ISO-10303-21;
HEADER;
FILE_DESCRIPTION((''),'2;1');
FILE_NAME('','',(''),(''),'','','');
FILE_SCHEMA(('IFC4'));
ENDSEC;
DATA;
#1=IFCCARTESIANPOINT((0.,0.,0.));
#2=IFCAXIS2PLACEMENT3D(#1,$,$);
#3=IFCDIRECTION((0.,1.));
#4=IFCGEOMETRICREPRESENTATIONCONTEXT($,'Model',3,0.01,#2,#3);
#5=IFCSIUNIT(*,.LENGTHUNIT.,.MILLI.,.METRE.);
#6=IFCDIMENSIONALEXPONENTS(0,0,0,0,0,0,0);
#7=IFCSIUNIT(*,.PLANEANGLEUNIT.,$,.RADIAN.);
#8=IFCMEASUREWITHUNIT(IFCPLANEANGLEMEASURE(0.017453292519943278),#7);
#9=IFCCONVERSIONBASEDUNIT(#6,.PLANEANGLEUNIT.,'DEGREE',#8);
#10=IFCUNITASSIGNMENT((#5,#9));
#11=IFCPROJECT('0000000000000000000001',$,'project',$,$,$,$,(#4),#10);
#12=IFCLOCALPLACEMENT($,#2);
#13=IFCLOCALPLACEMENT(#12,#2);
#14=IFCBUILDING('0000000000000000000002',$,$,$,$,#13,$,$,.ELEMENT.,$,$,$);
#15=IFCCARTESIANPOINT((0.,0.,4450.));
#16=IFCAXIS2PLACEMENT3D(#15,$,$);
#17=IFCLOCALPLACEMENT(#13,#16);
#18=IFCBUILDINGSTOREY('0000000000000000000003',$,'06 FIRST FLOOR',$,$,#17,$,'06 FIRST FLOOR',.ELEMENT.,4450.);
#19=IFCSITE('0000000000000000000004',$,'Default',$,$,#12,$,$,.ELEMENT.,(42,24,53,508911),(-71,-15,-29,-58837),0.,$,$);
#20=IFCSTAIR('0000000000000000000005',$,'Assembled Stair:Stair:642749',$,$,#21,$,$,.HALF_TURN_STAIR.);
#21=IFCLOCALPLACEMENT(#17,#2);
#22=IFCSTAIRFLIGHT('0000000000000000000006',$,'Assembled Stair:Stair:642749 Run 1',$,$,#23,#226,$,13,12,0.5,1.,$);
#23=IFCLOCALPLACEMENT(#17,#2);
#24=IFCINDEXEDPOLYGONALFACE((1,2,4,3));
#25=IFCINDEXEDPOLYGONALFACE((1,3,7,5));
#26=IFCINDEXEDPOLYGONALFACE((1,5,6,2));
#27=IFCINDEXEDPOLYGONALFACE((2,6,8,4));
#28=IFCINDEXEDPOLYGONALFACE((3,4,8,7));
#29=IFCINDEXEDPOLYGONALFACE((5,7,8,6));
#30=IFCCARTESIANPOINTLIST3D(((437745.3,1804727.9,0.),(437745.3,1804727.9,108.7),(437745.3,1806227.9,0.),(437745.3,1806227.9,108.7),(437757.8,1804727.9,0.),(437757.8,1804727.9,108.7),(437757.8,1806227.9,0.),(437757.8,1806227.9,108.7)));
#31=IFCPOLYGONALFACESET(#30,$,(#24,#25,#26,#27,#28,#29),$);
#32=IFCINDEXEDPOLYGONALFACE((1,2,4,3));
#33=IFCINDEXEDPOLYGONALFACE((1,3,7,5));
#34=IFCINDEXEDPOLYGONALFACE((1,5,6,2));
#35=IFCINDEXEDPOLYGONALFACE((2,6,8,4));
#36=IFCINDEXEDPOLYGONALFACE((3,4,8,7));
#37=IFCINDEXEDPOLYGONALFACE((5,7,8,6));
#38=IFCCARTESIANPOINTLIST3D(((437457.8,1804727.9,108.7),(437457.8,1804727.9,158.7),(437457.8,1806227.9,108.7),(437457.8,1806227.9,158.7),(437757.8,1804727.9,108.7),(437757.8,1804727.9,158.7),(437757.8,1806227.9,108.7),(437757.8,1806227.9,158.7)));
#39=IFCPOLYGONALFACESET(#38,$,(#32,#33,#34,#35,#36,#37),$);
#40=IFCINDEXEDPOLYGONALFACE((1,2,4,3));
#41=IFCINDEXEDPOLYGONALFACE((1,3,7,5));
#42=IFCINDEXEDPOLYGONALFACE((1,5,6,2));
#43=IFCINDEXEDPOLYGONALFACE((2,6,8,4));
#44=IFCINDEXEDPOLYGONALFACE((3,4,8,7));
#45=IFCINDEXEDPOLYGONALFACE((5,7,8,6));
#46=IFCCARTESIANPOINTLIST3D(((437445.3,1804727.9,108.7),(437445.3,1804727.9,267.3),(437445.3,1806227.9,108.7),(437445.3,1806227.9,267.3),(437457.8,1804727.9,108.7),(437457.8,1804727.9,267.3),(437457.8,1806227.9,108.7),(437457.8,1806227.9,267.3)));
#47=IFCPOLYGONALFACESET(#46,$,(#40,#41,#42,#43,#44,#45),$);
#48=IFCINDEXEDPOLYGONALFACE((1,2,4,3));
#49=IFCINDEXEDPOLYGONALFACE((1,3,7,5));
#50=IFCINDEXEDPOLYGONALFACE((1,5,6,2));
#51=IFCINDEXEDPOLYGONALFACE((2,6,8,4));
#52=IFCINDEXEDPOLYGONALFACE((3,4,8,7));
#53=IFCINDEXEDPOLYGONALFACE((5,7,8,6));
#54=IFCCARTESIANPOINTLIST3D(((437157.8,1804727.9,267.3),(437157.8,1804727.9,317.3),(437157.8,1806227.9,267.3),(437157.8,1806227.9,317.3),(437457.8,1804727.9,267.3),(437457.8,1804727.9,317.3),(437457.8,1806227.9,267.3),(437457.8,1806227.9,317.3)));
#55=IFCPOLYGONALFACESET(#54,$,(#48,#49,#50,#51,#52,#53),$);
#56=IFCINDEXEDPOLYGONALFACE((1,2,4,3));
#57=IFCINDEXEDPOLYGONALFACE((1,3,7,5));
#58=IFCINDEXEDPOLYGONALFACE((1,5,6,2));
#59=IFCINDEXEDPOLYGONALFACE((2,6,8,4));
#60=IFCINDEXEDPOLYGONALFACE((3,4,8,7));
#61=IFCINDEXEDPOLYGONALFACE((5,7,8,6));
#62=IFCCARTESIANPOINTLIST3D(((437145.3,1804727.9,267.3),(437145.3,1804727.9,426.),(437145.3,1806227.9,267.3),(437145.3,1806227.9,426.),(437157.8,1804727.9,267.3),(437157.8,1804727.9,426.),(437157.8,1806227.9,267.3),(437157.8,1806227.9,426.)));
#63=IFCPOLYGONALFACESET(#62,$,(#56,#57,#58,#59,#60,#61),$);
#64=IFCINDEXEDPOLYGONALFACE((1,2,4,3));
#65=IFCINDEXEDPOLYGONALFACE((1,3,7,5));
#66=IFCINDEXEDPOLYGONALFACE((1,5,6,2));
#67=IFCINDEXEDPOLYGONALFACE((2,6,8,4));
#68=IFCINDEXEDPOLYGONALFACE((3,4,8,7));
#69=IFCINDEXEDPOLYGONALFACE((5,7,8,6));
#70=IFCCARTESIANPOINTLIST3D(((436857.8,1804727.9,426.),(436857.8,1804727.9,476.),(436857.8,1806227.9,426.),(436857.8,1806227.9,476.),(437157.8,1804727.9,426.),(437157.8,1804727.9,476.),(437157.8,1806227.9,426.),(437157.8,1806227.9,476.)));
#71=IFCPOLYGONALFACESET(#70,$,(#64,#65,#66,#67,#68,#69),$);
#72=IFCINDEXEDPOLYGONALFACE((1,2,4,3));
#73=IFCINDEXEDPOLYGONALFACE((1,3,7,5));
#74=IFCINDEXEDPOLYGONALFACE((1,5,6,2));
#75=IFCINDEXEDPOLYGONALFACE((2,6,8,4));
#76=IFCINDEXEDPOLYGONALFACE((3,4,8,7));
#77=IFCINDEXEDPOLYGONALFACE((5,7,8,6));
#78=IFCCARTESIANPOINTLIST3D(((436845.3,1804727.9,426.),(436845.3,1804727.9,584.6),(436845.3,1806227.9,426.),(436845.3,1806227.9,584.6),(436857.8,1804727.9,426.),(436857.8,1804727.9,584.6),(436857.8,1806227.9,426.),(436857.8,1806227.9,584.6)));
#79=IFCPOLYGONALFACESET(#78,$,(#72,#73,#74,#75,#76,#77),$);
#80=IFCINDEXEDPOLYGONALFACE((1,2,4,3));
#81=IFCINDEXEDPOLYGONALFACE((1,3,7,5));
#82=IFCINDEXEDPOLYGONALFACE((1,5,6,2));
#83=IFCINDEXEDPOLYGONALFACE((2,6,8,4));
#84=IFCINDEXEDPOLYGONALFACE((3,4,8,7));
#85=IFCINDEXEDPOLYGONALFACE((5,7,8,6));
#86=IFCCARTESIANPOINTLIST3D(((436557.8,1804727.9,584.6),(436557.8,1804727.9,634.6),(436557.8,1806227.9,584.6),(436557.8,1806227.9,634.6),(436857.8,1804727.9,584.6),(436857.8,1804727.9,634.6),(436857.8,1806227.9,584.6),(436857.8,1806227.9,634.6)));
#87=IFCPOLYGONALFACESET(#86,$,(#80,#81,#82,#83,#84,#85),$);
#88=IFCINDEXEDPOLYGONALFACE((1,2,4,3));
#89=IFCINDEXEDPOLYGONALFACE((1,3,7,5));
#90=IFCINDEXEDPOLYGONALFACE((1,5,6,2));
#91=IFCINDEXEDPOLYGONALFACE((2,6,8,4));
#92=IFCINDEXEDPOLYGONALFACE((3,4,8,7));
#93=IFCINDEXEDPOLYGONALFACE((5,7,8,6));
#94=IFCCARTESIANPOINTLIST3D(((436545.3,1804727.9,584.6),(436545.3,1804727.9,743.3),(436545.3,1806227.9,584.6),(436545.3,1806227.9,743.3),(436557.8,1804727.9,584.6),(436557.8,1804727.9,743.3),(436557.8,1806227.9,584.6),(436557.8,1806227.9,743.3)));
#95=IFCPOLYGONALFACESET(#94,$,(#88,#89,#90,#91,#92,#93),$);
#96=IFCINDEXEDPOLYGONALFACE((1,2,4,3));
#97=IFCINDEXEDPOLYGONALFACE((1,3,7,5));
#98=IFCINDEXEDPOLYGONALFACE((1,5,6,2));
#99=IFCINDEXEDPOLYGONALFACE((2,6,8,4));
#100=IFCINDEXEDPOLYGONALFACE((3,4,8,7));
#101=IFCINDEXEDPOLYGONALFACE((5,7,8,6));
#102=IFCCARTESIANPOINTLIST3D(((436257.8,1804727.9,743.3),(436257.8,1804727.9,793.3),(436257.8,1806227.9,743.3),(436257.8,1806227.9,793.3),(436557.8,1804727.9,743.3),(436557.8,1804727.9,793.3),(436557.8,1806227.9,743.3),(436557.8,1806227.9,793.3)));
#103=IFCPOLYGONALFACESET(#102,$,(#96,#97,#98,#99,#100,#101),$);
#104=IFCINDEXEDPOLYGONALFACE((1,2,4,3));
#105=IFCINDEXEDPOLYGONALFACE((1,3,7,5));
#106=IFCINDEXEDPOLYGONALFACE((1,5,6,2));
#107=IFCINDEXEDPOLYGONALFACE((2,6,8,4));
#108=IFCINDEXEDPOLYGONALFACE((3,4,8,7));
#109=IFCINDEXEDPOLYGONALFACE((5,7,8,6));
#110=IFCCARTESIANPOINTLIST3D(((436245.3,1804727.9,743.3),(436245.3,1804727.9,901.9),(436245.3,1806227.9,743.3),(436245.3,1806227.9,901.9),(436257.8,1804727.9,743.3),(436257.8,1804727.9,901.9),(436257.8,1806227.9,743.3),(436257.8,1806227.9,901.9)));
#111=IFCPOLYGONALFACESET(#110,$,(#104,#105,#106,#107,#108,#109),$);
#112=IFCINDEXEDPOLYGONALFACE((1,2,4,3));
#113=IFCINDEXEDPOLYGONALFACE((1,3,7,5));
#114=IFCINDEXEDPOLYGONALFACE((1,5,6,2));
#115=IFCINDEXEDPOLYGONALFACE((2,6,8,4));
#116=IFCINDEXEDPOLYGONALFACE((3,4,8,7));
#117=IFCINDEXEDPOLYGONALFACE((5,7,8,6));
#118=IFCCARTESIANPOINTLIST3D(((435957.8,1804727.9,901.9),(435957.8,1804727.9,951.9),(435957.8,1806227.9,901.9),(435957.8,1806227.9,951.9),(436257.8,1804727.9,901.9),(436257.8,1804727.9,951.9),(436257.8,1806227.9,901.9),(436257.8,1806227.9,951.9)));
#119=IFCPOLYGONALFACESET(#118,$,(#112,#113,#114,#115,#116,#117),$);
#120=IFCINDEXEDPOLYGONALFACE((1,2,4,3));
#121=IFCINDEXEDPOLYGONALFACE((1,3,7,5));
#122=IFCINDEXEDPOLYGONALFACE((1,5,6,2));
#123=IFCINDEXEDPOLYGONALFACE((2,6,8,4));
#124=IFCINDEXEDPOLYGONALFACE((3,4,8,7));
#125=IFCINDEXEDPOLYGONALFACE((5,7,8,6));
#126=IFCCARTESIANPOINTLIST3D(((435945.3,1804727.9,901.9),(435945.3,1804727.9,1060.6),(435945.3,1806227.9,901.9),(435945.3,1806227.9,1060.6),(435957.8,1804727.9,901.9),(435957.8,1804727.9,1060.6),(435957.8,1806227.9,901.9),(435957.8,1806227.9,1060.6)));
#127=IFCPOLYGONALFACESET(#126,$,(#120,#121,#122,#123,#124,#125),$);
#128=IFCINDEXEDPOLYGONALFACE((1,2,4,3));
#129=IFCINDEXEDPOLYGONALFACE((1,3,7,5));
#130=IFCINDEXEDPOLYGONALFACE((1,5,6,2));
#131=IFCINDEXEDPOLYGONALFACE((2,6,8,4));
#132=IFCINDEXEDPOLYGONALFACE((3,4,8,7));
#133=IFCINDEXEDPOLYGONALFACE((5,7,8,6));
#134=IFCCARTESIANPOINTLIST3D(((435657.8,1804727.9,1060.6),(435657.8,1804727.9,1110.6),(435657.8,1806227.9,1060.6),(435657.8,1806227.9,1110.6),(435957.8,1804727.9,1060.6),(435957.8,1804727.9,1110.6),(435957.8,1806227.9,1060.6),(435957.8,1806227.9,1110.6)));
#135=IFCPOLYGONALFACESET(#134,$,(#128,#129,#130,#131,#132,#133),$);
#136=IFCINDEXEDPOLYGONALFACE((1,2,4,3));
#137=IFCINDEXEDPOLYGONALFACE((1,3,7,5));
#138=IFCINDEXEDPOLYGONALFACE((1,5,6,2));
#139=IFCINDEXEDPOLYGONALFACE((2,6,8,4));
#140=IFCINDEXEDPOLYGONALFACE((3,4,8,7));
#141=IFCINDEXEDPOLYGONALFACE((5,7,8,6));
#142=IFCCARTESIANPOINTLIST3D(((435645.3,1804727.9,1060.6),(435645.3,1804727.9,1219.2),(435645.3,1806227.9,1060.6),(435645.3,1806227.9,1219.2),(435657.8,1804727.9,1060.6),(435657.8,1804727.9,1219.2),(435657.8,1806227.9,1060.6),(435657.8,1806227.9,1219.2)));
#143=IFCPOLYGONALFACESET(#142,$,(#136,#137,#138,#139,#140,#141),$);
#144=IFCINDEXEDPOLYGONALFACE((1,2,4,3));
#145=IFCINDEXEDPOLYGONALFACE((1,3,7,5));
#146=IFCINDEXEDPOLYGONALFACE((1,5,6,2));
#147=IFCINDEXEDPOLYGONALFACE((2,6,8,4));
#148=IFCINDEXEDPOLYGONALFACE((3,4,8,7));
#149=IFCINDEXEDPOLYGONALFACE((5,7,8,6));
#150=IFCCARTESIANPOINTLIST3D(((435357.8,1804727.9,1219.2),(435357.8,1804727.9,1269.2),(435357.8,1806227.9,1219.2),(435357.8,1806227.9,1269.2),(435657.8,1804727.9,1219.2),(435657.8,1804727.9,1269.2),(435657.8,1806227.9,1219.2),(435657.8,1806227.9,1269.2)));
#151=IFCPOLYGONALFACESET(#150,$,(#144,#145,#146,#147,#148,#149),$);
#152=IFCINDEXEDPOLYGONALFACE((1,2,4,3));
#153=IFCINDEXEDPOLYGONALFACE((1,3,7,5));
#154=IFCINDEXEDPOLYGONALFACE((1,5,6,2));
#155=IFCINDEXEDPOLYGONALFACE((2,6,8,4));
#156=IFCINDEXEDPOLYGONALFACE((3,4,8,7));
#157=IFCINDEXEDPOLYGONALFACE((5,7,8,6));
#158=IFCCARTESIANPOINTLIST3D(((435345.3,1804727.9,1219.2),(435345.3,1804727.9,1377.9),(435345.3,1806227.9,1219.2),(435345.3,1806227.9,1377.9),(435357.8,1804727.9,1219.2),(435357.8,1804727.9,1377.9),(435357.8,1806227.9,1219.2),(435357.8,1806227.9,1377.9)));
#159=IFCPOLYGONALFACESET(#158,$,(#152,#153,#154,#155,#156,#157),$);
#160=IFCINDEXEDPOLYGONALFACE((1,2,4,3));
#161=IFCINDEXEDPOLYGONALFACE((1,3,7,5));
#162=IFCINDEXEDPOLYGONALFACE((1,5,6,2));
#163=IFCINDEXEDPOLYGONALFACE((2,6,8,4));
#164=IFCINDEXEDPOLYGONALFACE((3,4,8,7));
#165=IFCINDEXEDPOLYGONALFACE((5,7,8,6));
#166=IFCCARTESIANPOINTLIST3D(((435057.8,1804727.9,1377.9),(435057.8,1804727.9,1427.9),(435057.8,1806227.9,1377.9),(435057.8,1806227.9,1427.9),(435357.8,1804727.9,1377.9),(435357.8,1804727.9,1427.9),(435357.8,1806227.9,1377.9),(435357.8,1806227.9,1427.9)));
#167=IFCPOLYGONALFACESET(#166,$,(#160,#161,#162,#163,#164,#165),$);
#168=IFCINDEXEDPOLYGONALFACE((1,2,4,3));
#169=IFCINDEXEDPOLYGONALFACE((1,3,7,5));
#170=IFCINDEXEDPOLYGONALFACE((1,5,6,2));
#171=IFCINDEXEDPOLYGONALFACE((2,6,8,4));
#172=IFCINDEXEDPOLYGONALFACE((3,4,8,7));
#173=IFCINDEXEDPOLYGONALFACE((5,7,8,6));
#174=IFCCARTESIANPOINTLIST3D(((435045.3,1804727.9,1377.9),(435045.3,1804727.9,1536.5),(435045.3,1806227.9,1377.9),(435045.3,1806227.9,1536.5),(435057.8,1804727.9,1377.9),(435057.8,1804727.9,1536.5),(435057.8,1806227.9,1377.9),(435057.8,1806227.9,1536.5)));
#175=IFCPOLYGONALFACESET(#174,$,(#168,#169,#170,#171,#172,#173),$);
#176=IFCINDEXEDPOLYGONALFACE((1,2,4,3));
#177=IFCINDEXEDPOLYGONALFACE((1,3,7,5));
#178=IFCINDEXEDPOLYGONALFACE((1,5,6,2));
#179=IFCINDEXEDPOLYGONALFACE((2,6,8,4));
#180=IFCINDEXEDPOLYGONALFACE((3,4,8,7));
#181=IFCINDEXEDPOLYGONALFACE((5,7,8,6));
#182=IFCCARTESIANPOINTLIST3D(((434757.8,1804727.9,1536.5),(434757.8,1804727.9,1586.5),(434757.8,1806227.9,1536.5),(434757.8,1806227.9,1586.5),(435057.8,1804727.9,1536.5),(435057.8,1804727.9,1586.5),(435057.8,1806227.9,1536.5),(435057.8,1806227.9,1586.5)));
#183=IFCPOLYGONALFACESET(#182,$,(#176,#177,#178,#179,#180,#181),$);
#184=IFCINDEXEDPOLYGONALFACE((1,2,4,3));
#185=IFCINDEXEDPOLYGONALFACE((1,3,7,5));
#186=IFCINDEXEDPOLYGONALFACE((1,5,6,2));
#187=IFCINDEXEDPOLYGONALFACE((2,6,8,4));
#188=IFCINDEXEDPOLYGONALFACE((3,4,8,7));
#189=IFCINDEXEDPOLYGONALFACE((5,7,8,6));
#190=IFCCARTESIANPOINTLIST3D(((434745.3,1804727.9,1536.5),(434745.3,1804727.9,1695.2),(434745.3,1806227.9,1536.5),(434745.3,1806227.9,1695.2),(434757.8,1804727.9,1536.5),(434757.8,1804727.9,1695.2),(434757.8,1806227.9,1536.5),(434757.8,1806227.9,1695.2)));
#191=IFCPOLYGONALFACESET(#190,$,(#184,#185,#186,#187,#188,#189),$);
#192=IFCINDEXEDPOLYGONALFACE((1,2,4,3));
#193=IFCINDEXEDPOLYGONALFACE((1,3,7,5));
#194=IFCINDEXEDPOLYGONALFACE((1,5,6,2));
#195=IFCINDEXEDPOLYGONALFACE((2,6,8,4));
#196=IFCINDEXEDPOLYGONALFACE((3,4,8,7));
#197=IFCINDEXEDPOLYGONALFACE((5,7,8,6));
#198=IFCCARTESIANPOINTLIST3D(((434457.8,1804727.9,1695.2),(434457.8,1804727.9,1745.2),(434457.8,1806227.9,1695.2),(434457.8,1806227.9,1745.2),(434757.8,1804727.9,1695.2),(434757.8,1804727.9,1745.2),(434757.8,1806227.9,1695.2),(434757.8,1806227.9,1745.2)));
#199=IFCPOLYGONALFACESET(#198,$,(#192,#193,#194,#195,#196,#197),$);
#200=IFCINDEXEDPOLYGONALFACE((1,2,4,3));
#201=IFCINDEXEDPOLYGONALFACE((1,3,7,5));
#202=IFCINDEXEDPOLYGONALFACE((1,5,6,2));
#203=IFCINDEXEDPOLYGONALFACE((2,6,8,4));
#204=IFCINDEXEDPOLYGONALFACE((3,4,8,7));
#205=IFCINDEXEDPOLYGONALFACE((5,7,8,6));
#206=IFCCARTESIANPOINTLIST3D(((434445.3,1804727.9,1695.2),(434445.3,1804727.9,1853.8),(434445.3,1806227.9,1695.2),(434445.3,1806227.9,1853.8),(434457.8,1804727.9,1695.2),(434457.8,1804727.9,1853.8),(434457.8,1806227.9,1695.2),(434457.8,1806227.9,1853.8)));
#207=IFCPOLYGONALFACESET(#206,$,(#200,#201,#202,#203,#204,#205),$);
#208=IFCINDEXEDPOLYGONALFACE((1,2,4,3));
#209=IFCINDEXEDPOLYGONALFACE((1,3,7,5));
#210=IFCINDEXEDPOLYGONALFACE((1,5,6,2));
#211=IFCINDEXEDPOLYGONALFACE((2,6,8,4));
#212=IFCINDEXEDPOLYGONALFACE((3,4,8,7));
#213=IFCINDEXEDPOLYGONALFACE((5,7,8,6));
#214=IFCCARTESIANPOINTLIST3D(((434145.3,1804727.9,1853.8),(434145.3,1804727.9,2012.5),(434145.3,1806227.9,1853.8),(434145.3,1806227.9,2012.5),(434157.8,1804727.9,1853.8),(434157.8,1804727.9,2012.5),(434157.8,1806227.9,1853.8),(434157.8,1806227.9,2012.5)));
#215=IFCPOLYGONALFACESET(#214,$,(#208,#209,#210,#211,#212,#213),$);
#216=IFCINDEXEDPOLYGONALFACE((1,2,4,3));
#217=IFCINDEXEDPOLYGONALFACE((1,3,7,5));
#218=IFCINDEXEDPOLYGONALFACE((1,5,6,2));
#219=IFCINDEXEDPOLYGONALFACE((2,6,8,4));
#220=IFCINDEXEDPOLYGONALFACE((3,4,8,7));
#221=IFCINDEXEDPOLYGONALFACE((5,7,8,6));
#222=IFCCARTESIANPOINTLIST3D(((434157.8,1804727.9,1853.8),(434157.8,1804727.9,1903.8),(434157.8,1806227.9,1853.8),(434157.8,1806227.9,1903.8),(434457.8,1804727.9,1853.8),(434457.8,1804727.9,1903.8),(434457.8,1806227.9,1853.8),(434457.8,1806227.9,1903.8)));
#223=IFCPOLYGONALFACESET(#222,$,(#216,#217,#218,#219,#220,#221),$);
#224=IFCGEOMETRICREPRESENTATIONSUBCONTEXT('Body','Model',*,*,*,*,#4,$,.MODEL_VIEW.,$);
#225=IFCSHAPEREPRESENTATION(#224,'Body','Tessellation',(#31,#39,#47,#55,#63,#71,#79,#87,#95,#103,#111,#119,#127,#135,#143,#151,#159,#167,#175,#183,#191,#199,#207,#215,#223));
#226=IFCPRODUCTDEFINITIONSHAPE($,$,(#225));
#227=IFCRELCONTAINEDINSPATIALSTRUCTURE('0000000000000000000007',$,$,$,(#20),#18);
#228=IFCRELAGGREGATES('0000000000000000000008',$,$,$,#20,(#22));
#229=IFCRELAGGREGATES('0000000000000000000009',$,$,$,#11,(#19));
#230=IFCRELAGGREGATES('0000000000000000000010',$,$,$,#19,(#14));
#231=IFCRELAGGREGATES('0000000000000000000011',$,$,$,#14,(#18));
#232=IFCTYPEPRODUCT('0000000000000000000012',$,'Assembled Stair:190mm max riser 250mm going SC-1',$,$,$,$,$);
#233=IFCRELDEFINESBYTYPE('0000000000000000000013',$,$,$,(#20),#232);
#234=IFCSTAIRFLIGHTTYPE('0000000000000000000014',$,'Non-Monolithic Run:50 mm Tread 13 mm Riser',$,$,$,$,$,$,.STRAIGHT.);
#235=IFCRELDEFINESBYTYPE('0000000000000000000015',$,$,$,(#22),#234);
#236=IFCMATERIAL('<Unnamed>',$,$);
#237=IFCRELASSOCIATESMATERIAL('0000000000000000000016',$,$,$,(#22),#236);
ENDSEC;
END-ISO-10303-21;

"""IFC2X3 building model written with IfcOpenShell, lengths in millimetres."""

from ifc_helpers import new_model, entity, si_unit, converted_unit, direction, frame, origin, origin_2d_with_axis, place, context, subcontext, project, spatial, rectangle, extrude, material, type_object, element, aggregate, save


model = new_model("IFC2X3")

# Units and contexts
model_context = context("Model", 3, precision=0.01, world=origin(), true_north=direction((0.0, 1.0)))
body_context = subcontext(model_context, "Body", "Model", "MODEL_VIEW")
ifc_project = project(units=[si_unit("LENGTHUNIT", "METRE", prefix="MILLI"), converted_unit("PLANEANGLEUNIT", "DEGREE", entity("IfcPlaneAngleMeasure", 0.017453292519943278), si_unit("PLANEANGLEUNIT", "RADIAN"), dimensions=[0, 0, 0, 0, 0, 0, 0])], contexts=[model_context])

# Site, building, storey
site_placement = place(None, origin())
site = spatial("IfcSite", under=ifc_project, at=site_placement, Name="Default", CompositionType="ELEMENT", RefLatitude=(42, 24, 53, 508911), RefLongitude=(-71, -15, -29, -58837), RefElevation=0.0)
building_placement = place(site_placement, origin())
building = spatial("IfcBuilding", under=site, at=building_placement, CompositionType="ELEMENT")
storey_placement = place(building_placement, frame((0.0, 0.0, 4450.0)))
storey = spatial("IfcBuildingStorey", under=building, at=storey_placement, Name="06 FIRST FLOOR", LongName="06 FIRST FLOOR", CompositionType="ELEMENT", Elevation=4450.0)

# Stair
type_product_1 = type_object("IfcTypeProduct", Name="Assembled Stair:190mm max riser 250mm going SC-1")
stair_1_placement = place(storey_placement, origin())
stair_1 = element("IfcStair", 1, at=stair_1_placement, inside=storey, type_object=type_product_1, Name="Assembled Stair:Stair:642749", ShapeType="HALF_TURN_STAIR")
ifc_material_1 = material(Name="<Unnamed>")

# Stair flight
stair_flight_type = type_object("IfcStairFlightType", Name="Non-Monolithic Run:50 mm Tread 13 mm Riser", PredefinedType="STRAIGHT")
stair_flight_1_placement = place(stair_1_placement, origin())
stair_flight_1 = element("IfcStairFlight", 2, at=stair_flight_1_placement, type_object=stair_flight_type, material=ifc_material_1, Name="Assembled Stair:Stair:642749 Run 1", NumberOfRiser=13, NumberOfTreads=12, RiserHeight=0.5, TreadLength=1.0, context=body_context, shape_type="SweptSolid", body=[
    extrude(rectangle(XDim=1500.0, YDim=12.5, at=origin_2d_with_axis()), frame((437751.5, 1805477.9, 0.0), z_axis=(0.0, 0.0, 1.0), x_axis=(0.0, -1.0, 0.0)), (0.0, 0.0, 1.0), 108.7),
    extrude(rectangle(XDim=300.0, YDim=1500.0, at=origin_2d_with_axis()), frame((437607.8, 1805477.9, 108.7)), (0.0, 0.0, 1.0), 50.0),
    extrude(rectangle(XDim=1500.0, YDim=12.5, at=origin_2d_with_axis()), frame((437451.5, 1805477.9, 108.7), z_axis=(0.0, 0.0, 1.0), x_axis=(0.0, -1.0, 0.0)), (0.0, 0.0, 1.0), 158.7),
    extrude(rectangle(XDim=300.0, YDim=1500.0, at=origin_2d_with_axis()), frame((437307.8, 1805477.9, 267.3)), (0.0, 0.0, 1.0), 50.0),
    extrude(rectangle(XDim=1500.0, YDim=12.5, at=origin_2d_with_axis()), frame((437151.5, 1805477.9, 267.3), z_axis=(0.0, 0.0, 1.0), x_axis=(0.0, -1.0, 0.0)), (0.0, 0.0, 1.0), 158.7),
    extrude(rectangle(XDim=300.0, YDim=1500.0, at=origin_2d_with_axis()), frame((437007.8, 1805477.9, 426.0)), (0.0, 0.0, 1.0), 50.0),
    extrude(rectangle(XDim=1500.0, YDim=12.5, at=origin_2d_with_axis()), frame((436851.5, 1805477.9, 426.0), z_axis=(0.0, 0.0, 1.0), x_axis=(0.0, -1.0, 0.0)), (0.0, 0.0, 1.0), 158.7),
    extrude(rectangle(XDim=300.0, YDim=1500.0, at=origin_2d_with_axis()), frame((436707.8, 1805477.9, 584.6)), (0.0, 0.0, 1.0), 50.0),
    extrude(rectangle(XDim=1500.0, YDim=12.5, at=origin_2d_with_axis()), frame((436551.5, 1805477.9, 584.6), z_axis=(0.0, 0.0, 1.0), x_axis=(0.0, -1.0, 0.0)), (0.0, 0.0, 1.0), 158.7),
    extrude(rectangle(XDim=300.0, YDim=1500.0, at=origin_2d_with_axis()), frame((436407.8, 1805477.9, 743.3)), (0.0, 0.0, 1.0), 50.0),
    extrude(rectangle(XDim=1500.0, YDim=12.5, at=origin_2d_with_axis()), frame((436251.5, 1805477.9, 743.3), z_axis=(0.0, 0.0, 1.0), x_axis=(0.0, -1.0, 0.0)), (0.0, 0.0, 1.0), 158.7),
    extrude(rectangle(XDim=300.0, YDim=1500.0, at=origin_2d_with_axis()), frame((436107.8, 1805477.9, 901.9)), (0.0, 0.0, 1.0), 50.0),
    extrude(rectangle(XDim=1500.0, YDim=12.5, at=origin_2d_with_axis()), frame((435951.5, 1805477.9, 901.9), z_axis=(0.0, 0.0, 1.0), x_axis=(0.0, -1.0, 0.0)), (0.0, 0.0, 1.0), 158.7),
    extrude(rectangle(XDim=300.0, YDim=1500.0, at=origin_2d_with_axis()), frame((435807.8, 1805477.9, 1060.6)), (0.0, 0.0, 1.0), 50.0),
    extrude(rectangle(XDim=1500.0, YDim=12.5, at=origin_2d_with_axis()), frame((435651.5, 1805477.9, 1060.6), z_axis=(0.0, 0.0, 1.0), x_axis=(0.0, -1.0, 0.0)), (0.0, 0.0, 1.0), 158.7),
    extrude(rectangle(XDim=300.0, YDim=1500.0, at=origin_2d_with_axis()), frame((435507.8, 1805477.9, 1219.2)), (0.0, 0.0, 1.0), 50.0),
    extrude(rectangle(XDim=1500.0, YDim=12.5, at=origin_2d_with_axis()), frame((435351.5, 1805477.9, 1219.2), z_axis=(0.0, 0.0, 1.0), x_axis=(0.0, -1.0, 0.0)), (0.0, 0.0, 1.0), 158.7),
    extrude(rectangle(XDim=300.0, YDim=1500.0, at=origin_2d_with_axis()), frame((435207.8, 1805477.9, 1377.9)), (0.0, 0.0, 1.0), 50.0),
    extrude(rectangle(XDim=1500.0, YDim=12.5, at=origin_2d_with_axis()), frame((435051.5, 1805477.9, 1377.9), z_axis=(0.0, 0.0, 1.0), x_axis=(0.0, -1.0, 0.0)), (0.0, 0.0, 1.0), 158.7),
    extrude(rectangle(XDim=300.0, YDim=1500.0, at=origin_2d_with_axis()), frame((434907.8, 1805477.9, 1536.5)), (0.0, 0.0, 1.0), 50.0),
    extrude(rectangle(XDim=1500.0, YDim=12.5, at=origin_2d_with_axis()), frame((434751.5, 1805477.9, 1536.5), z_axis=(0.0, 0.0, 1.0), x_axis=(0.0, -1.0, 0.0)), (0.0, 0.0, 1.0), 158.7),
    extrude(rectangle(XDim=300.0, YDim=1500.0, at=origin_2d_with_axis()), frame((434607.8, 1805477.9, 1695.2)), (0.0, 0.0, 1.0), 50.0),
    extrude(rectangle(XDim=1500.0, YDim=12.5, at=origin_2d_with_axis()), frame((434451.5, 1805477.9, 1695.2), z_axis=(0.0, 0.0, 1.0), x_axis=(0.0, -1.0, 0.0)), (0.0, 0.0, 1.0), 158.7),
    extrude(rectangle(XDim=1500.0, YDim=12.5, at=origin_2d_with_axis()), frame((434151.5, 1805477.9, 1853.8), z_axis=(0.0, 0.0, 1.0), x_axis=(0.0, -1.0, 0.0)), (0.0, 0.0, 1.0), 158.7),
    extrude(rectangle(XDim=300.0, YDim=1500.0, at=origin_2d_with_axis()), frame((434307.8, 1805477.9, 1853.8)), (0.0, 0.0, 1.0), 50.0),
])
aggregate(stair_1, [stair_flight_1])

save(model, "model.ifc")
